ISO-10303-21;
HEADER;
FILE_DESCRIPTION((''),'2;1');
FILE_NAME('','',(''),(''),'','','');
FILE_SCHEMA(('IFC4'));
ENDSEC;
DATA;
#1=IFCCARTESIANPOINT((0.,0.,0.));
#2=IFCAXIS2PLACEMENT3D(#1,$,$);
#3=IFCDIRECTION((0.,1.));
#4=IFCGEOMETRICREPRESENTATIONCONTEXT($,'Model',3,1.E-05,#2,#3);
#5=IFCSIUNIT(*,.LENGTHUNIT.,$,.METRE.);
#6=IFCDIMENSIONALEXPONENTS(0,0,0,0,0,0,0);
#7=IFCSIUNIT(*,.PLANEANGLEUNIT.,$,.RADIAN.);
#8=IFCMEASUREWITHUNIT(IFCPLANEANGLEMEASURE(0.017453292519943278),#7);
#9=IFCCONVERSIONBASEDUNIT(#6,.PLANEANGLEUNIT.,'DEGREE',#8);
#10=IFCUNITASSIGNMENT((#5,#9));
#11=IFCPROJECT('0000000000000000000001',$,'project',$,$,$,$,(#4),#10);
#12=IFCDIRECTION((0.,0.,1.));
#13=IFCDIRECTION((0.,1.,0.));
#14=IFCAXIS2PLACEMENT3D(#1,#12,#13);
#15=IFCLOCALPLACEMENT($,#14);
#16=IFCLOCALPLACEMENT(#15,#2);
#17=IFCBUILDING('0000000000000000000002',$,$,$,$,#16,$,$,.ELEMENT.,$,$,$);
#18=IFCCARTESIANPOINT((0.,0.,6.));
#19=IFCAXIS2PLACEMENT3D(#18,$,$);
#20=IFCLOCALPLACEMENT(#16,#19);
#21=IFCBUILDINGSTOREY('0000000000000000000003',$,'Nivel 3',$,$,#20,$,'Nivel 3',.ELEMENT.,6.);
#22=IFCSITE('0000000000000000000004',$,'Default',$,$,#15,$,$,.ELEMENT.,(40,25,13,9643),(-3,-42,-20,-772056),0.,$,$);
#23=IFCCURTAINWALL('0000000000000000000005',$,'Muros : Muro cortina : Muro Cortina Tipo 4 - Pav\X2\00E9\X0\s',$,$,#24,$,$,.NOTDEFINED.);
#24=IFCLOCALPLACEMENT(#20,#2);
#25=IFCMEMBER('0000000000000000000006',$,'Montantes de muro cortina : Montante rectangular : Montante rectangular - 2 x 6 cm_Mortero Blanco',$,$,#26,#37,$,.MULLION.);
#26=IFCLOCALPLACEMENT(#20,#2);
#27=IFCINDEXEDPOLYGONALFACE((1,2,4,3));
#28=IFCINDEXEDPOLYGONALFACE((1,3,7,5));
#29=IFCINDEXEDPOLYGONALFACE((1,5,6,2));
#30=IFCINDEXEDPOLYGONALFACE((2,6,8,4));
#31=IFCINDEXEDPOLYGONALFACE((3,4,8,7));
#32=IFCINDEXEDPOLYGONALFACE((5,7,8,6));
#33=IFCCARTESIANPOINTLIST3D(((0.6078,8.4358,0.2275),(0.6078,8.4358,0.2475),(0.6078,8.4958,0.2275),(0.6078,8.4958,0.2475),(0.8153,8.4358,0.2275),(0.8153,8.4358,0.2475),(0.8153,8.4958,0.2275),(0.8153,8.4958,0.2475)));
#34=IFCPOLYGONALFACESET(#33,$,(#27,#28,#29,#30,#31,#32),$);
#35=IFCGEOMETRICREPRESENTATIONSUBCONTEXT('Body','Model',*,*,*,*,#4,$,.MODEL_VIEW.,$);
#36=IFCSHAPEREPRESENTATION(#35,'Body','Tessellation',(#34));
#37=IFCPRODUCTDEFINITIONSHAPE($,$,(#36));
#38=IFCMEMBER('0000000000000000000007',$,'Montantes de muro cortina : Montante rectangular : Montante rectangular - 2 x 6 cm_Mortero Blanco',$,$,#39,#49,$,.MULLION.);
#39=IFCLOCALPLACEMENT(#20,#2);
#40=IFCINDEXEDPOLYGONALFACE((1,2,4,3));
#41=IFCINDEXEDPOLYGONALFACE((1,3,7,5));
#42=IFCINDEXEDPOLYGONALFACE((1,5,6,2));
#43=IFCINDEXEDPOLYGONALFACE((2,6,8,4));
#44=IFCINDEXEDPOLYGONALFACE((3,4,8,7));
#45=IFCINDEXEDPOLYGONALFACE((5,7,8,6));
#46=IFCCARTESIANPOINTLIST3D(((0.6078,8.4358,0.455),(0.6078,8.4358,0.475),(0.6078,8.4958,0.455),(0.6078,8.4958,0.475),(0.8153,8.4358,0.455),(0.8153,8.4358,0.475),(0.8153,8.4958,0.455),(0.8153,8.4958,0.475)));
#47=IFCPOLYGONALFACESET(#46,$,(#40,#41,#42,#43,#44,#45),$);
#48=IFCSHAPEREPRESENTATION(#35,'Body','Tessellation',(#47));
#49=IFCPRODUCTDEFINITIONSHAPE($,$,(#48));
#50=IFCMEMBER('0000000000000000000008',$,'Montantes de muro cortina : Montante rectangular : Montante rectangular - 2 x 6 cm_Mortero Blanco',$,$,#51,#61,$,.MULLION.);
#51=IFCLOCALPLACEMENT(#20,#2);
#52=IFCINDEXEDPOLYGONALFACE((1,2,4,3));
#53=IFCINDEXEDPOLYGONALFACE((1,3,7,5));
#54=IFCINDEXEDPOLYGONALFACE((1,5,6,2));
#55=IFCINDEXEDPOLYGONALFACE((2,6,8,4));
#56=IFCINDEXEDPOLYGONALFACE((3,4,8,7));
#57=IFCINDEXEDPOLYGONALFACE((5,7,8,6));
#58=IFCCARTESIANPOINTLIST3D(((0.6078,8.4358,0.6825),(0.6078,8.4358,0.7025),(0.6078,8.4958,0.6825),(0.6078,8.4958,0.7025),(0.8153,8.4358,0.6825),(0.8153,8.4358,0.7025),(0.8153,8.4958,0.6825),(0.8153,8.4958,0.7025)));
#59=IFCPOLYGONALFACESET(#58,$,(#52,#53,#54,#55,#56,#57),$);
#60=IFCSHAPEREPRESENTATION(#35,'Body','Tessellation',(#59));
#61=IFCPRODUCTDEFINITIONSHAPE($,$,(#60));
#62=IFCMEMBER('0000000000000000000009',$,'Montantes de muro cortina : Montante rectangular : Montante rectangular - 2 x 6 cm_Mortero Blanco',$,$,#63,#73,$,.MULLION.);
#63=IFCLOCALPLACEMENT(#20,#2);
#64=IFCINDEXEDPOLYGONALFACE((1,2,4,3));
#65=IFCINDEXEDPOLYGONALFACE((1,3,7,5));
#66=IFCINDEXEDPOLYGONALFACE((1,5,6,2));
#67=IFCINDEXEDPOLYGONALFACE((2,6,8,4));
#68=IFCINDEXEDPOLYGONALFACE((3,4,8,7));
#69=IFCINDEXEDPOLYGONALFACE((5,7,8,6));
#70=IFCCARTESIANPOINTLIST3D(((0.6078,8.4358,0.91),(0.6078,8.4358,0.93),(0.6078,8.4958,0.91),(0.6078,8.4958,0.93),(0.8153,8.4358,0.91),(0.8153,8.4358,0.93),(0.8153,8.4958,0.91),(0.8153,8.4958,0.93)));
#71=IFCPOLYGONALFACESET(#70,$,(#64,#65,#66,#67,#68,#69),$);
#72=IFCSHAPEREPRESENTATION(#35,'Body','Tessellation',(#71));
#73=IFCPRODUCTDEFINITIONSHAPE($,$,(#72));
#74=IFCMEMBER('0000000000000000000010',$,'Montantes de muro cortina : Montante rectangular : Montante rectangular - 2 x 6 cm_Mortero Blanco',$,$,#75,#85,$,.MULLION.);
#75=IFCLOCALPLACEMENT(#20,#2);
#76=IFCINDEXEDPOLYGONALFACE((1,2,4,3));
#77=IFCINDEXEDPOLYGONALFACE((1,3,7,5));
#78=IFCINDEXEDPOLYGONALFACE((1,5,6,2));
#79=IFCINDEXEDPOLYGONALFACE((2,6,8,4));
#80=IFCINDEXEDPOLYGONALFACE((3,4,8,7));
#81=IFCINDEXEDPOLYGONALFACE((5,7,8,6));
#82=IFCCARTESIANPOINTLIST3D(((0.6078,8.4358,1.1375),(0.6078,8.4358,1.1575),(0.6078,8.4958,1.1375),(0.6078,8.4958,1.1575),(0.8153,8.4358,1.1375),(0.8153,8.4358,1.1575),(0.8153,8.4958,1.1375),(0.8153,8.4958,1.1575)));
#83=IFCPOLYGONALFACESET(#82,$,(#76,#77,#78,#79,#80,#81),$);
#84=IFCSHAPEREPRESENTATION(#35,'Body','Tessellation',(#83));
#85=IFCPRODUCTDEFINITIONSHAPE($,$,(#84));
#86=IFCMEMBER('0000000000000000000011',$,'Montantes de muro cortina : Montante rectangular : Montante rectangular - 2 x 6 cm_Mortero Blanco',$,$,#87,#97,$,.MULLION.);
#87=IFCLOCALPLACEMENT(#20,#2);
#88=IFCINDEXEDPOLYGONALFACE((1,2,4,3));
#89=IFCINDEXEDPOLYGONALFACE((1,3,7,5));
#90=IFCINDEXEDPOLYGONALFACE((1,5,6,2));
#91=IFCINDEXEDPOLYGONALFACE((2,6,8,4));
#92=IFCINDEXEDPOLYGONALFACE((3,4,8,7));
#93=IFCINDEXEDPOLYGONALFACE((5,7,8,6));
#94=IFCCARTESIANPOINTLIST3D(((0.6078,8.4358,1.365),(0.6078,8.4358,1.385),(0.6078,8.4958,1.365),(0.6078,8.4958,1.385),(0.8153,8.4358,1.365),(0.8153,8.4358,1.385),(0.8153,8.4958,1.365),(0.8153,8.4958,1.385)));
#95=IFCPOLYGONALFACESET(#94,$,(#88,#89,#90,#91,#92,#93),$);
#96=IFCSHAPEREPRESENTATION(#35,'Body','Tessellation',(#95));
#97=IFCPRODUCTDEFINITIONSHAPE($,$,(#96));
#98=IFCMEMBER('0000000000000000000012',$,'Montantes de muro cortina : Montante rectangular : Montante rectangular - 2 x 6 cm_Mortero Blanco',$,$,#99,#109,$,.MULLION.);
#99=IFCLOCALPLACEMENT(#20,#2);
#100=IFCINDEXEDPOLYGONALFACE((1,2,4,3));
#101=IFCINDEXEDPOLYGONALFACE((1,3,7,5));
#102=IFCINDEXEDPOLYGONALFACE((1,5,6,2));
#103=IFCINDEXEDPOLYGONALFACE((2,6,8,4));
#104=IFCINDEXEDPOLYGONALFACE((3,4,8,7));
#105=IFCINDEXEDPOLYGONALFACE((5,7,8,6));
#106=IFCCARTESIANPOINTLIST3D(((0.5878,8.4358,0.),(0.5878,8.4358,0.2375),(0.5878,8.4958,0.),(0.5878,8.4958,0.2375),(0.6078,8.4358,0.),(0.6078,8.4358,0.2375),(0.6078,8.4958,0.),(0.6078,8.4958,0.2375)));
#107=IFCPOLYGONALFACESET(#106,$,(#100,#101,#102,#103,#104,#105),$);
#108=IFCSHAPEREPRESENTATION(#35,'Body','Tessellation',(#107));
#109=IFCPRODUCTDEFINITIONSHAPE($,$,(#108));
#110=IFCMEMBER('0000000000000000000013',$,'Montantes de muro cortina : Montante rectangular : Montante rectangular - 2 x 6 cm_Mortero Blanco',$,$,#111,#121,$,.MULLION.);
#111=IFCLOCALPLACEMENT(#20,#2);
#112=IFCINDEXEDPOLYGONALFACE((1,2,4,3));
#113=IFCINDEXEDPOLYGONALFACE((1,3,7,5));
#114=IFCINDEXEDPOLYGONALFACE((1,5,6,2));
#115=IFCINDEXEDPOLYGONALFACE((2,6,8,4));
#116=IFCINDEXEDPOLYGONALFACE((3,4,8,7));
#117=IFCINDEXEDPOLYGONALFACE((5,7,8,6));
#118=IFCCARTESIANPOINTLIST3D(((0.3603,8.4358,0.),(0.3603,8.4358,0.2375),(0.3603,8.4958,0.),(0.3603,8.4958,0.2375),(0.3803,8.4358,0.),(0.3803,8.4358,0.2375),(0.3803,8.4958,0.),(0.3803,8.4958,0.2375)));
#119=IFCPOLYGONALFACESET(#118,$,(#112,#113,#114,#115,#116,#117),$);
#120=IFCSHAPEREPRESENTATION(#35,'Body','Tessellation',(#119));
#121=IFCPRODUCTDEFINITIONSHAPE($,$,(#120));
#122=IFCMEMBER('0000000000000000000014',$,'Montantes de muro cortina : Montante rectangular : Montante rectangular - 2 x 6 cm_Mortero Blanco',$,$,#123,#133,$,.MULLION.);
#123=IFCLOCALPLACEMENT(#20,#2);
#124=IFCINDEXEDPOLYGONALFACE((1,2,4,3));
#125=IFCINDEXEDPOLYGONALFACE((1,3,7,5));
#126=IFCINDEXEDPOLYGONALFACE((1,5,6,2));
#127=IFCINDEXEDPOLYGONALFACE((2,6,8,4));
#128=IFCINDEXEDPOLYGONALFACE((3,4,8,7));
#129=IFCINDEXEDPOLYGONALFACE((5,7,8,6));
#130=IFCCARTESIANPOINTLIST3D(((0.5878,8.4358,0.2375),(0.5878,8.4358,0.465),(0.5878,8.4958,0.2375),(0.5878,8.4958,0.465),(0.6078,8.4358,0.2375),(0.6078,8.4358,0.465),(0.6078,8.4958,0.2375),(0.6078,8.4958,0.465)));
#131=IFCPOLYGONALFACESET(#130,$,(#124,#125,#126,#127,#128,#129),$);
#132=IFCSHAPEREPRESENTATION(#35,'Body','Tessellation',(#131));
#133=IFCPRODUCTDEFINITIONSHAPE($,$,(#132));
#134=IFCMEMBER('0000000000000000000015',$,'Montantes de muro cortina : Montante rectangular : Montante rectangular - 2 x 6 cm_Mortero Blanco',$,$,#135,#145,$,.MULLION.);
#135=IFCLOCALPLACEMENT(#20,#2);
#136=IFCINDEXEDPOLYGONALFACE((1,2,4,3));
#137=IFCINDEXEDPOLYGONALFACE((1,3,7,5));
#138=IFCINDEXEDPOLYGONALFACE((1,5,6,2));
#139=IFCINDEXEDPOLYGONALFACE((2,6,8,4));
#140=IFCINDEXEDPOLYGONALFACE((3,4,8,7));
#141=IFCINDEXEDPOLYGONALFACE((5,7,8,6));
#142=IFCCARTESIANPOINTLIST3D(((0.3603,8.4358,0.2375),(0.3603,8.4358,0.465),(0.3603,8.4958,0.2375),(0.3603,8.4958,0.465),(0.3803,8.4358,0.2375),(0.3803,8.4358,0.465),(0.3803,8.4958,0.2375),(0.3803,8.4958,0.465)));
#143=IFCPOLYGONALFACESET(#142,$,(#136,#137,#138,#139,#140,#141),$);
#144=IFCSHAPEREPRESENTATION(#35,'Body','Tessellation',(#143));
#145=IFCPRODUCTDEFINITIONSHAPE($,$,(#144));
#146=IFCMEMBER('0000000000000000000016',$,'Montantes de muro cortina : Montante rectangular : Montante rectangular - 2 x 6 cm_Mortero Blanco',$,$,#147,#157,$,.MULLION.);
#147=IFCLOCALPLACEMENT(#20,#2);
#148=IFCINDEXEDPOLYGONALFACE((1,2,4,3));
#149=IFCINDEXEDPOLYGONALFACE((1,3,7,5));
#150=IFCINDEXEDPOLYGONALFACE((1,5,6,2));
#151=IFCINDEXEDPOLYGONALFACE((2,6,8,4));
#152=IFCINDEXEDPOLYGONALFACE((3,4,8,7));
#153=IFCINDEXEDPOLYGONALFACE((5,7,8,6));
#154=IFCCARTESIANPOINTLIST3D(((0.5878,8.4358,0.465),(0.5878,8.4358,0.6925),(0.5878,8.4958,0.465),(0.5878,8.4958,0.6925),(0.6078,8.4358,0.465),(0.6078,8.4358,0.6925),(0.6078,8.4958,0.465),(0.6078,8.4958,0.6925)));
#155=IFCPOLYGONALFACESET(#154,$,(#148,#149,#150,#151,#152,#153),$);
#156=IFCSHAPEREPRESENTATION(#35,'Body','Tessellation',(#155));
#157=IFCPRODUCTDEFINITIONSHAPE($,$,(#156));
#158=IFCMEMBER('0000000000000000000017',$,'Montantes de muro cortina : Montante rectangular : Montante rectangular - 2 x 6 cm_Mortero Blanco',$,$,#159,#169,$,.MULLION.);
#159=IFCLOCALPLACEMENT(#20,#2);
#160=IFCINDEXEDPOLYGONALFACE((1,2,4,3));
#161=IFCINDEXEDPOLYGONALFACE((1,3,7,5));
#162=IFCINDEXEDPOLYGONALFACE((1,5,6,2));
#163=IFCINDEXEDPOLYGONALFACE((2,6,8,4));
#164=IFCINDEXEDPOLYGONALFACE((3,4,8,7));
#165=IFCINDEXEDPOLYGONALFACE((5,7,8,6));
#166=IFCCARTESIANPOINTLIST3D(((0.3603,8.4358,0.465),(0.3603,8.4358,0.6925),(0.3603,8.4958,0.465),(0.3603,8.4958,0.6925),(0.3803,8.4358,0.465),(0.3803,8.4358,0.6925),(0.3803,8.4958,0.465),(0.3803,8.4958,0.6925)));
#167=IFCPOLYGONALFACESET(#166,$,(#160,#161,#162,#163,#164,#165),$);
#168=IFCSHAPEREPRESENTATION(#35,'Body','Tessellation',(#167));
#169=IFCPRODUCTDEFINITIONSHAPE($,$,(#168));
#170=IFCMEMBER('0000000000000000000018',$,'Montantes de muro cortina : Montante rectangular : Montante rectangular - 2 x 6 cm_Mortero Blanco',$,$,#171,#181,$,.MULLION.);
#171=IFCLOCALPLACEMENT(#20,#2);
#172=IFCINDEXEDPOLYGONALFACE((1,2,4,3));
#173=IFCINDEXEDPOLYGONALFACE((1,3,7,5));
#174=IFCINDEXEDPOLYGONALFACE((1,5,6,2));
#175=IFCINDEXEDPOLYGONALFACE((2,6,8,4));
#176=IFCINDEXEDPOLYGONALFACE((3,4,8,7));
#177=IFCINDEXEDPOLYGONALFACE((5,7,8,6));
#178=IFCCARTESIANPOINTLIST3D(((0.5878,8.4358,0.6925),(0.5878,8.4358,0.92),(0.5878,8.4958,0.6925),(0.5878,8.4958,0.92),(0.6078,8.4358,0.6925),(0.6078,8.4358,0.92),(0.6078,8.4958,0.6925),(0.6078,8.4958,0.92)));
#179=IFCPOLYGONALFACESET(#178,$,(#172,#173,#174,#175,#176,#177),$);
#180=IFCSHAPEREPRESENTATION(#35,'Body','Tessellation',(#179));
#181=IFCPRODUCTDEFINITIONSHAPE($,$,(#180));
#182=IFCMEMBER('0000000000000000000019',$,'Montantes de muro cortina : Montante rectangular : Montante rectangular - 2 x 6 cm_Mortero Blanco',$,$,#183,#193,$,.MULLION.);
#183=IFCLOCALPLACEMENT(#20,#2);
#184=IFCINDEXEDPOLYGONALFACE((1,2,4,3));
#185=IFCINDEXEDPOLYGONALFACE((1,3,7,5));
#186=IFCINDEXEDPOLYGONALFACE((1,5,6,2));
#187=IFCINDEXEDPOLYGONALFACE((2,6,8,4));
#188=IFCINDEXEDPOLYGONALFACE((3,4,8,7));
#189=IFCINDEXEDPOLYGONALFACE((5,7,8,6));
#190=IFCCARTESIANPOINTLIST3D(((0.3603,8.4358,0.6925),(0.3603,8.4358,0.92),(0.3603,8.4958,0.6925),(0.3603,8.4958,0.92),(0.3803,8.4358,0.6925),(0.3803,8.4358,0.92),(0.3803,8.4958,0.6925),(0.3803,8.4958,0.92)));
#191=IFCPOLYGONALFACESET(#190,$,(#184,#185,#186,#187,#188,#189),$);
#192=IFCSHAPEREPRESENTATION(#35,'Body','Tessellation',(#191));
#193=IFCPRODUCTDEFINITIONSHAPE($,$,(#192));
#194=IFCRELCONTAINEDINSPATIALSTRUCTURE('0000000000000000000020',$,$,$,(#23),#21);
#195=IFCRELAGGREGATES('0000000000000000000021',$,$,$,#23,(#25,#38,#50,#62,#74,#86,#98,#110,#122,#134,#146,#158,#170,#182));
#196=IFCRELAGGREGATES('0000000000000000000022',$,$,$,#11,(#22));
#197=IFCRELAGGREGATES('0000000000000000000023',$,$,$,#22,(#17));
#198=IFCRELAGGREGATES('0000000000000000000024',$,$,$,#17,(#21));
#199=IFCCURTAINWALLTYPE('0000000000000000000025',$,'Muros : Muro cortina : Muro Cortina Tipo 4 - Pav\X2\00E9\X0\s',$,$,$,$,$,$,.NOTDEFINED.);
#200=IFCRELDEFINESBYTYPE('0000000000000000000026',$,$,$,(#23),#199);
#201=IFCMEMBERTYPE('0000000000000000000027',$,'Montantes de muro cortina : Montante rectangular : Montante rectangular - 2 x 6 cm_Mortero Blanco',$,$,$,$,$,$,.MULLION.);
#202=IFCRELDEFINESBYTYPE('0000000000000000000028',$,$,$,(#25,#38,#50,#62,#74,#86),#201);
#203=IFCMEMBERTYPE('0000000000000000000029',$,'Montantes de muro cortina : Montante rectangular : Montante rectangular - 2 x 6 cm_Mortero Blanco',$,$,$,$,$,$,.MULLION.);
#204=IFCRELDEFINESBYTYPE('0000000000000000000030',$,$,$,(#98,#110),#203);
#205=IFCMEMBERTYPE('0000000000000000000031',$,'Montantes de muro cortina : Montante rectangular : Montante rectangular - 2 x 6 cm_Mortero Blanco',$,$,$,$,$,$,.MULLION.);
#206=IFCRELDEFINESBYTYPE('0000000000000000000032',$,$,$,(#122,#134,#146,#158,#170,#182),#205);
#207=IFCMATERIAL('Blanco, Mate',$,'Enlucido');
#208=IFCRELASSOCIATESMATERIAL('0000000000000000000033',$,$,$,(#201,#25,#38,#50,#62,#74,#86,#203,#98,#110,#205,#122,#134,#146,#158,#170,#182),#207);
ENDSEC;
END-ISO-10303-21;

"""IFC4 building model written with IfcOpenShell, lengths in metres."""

from ifc_helpers import new_model, entity, si_unit, converted_unit, direction, frame, origin, place, context, subcontext, project, spatial, indexed_curve, outline, extrude, source, transform, mapped, material, type_object, type_shapes, element, aggregate, save


model = new_model("IFC4")

# Units and contexts
model_context = context("Model", 3, precision=1e-05, world=origin(), true_north=direction((0.0, 1.0)))
body_context = subcontext(model_context, "Body", "Model", "MODEL_VIEW")
ifc_project = project(units=[si_unit("LENGTHUNIT", "METRE"), converted_unit("PLANEANGLEUNIT", "DEGREE", entity("IfcPlaneAngleMeasure", 0.017453292519943278), si_unit("PLANEANGLEUNIT", "RADIAN"), dimensions=[0, 0, 0, 0, 0, 0, 0])], contexts=[model_context])

# Site, building, storey
site_placement = place(None, frame((0.0, 0.0, 0.0), z_axis=(0.0, 0.0, 1.0), x_axis=(0.0, 1.0, 0.0)))
site = spatial("IfcSite", under=ifc_project, at=site_placement, Name="Default", CompositionType="ELEMENT", RefLatitude=(40, 25, 13, 9643), RefLongitude=(-3, -42, -20, -772056), RefElevation=0.0)
building_placement = place(site_placement, origin())
building = spatial("IfcBuilding", under=site, at=building_placement, CompositionType="ELEMENT")
storey_placement = place(building_placement, frame((0.0, 0.0, 6.0)))
storey = spatial("IfcBuildingStorey", under=building, at=storey_placement, Name="Nivel 3", LongName="Nivel 3", CompositionType="ELEMENT", Elevation=6.0)

# Curtain wall, members
curtain_wall_type = type_object("IfcCurtainWallType", Name="Muros : Muro cortina : Muro Cortina Tipo 4 - Pavés", PredefinedType="NOTDEFINED")
curtain_wall_placement = place(storey_placement, frame((0.0, 0.0, -6.0)))
curtain_wall = element("IfcCurtainWall", 1, at=curtain_wall_placement, inside=storey, type_object=curtain_wall_type, Name="Muros : Muro cortina : Muro Cortina Tipo 4 - Pavés", PredefinedType="NOTDEFINED")
ifc_material_1 = material(Name="Blanco, Mate", Category="Enlucido")
member_type_1 = type_object("IfcMemberType", Name="Montantes de muro cortina : Montante rectangular : Montante rectangular - 2 x 6 cm_Mortero Blanco", PredefinedType="MULLION", material=ifc_material_1)
shared_shape_1 = source(origin(), body_context, "Body", "SweptSolid", [
    extrude(outline(indexed_curve([(-0.01, -0.03), (0.01, -0.03), (0.01, 0.03), (-0.01, 0.03), (-0.01, -0.03)], self_intersect=False)), frame((0.0, 0.0, -0.2075), z_axis=(0.0, 0.0, 1.0), x_axis=(-1.0, 0.0, 0.0)), (0.0, 0.0, 1.0), 0.2075),
])
type_shapes(member_type_1, [shared_shape_1])
member_1_placement = place(curtain_wall_placement, frame((0.6078, 8.4658, 6.2375), z_axis=(-1.0, 0.0, 0.0), x_axis=(0.0, 0.0, 1.0)))
member_1 = element("IfcMember", 2, at=member_1_placement, type_object=member_type_1, material=ifc_material_1, Name="Montantes de muro cortina : Montante rectangular : Montante rectangular - 2 x 6 cm_Mortero Blanco", PredefinedType="MULLION", context=body_context, shape_type="MappedRepresentation", body=[
    mapped(shared_shape_1, transform((0.0, 0.0, 0.0), scale=1.0)),
])
member_2_placement = place(curtain_wall_placement, frame((0.6078, 8.4658, 6.465), z_axis=(-1.0, 0.0, 0.0), x_axis=(0.0, 0.0, 1.0)))
member_2 = element("IfcMember", 3, at=member_2_placement, type_object=member_type_1, material=ifc_material_1, Name="Montantes de muro cortina : Montante rectangular : Montante rectangular - 2 x 6 cm_Mortero Blanco", PredefinedType="MULLION", context=body_context, shape_type="MappedRepresentation", body=[
    mapped(shared_shape_1, transform((0.0, 0.0, 0.0), scale=1.0)),
])
member_3_placement = place(curtain_wall_placement, frame((0.6078, 8.4658, 6.6925), z_axis=(-1.0, 0.0, 0.0), x_axis=(0.0, 0.0, 1.0)))
member_3 = element("IfcMember", 4, at=member_3_placement, type_object=member_type_1, material=ifc_material_1, Name="Montantes de muro cortina : Montante rectangular : Montante rectangular - 2 x 6 cm_Mortero Blanco", PredefinedType="MULLION", context=body_context, shape_type="MappedRepresentation", body=[
    mapped(shared_shape_1, transform((0.0, 0.0, 0.0), scale=1.0)),
])
member_4_placement = place(curtain_wall_placement, frame((0.6078, 8.4658, 6.92), z_axis=(-1.0, 0.0, 0.0), x_axis=(0.0, 0.0, 1.0)))
member_4 = element("IfcMember", 5, at=member_4_placement, type_object=member_type_1, material=ifc_material_1, Name="Montantes de muro cortina : Montante rectangular : Montante rectangular - 2 x 6 cm_Mortero Blanco", PredefinedType="MULLION", context=body_context, shape_type="MappedRepresentation", body=[
    mapped(shared_shape_1, transform((0.0, 0.0, 0.0), scale=1.0)),
])
member_5_placement = place(curtain_wall_placement, frame((0.6078, 8.4658, 7.1475), z_axis=(-1.0, 0.0, 0.0), x_axis=(0.0, 0.0, 1.0)))
member_5 = element("IfcMember", 6, at=member_5_placement, type_object=member_type_1, material=ifc_material_1, Name="Montantes de muro cortina : Montante rectangular : Montante rectangular - 2 x 6 cm_Mortero Blanco", PredefinedType="MULLION", context=body_context, shape_type="MappedRepresentation", body=[
    mapped(shared_shape_1, transform((0.0, 0.0, 0.0), scale=1.0)),
])
member_6_placement = place(curtain_wall_placement, frame((0.6078, 8.4658, 7.375), z_axis=(-1.0, 0.0, 0.0), x_axis=(0.0, 0.0, 1.0)))
member_6 = element("IfcMember", 7, at=member_6_placement, type_object=member_type_1, material=ifc_material_1, Name="Montantes de muro cortina : Montante rectangular : Montante rectangular - 2 x 6 cm_Mortero Blanco", PredefinedType="MULLION", context=body_context, shape_type="MappedRepresentation", body=[
    mapped(shared_shape_1, transform((0.0, 0.0, 0.0), scale=1.0)),
])
member_type_2 = type_object("IfcMemberType", Name="Montantes de muro cortina : Montante rectangular : Montante rectangular - 2 x 6 cm_Mortero Blanco", PredefinedType="MULLION", material=ifc_material_1)
shared_shape_2 = source(origin(), body_context, "Body", "SweptSolid", [
    extrude(outline(indexed_curve([(-0.01, -0.03), (0.01, -0.03), (0.01, 0.03), (-0.01, 0.03), (-0.01, -0.03)], self_intersect=False)), frame((0.0, 0.0, -0.2375), z_axis=(0.0, 0.0, 1.0), x_axis=(-1.0, 0.0, 0.0)), (0.0, 0.0, 1.0), 0.2375),
])
type_shapes(member_type_2, [shared_shape_2])
member_7_placement = place(curtain_wall_placement, frame((0.5978, 8.4658, 6.0), z_axis=(0.0, 0.0, -1.0), x_axis=(-1.0, 0.0, 0.0)))
member_7 = element("IfcMember", 8, at=member_7_placement, type_object=member_type_2, material=ifc_material_1, Name="Montantes de muro cortina : Montante rectangular : Montante rectangular - 2 x 6 cm_Mortero Blanco", PredefinedType="MULLION", context=body_context, shape_type="MappedRepresentation", body=[
    mapped(shared_shape_2, transform((0.0, 0.0, 0.0), scale=1.0)),
])
member_8_placement = place(curtain_wall_placement, frame((0.3703, 8.4658, 6.0), z_axis=(0.0, 0.0, -1.0), x_axis=(-1.0, 0.0, 0.0)))
member_8 = element("IfcMember", 9, at=member_8_placement, type_object=member_type_2, material=ifc_material_1, Name="Montantes de muro cortina : Montante rectangular : Montante rectangular - 2 x 6 cm_Mortero Blanco", PredefinedType="MULLION", context=body_context, shape_type="MappedRepresentation", body=[
    mapped(shared_shape_2, transform((0.0, 0.0, 0.0), scale=1.0)),
])
member_type_3 = type_object("IfcMemberType", Name="Montantes de muro cortina : Montante rectangular : Montante rectangular - 2 x 6 cm_Mortero Blanco", PredefinedType="MULLION", material=ifc_material_1)
shared_shape_3 = source(origin(), body_context, "Body", "SweptSolid", [
    extrude(outline(indexed_curve([(-0.01, -0.03), (0.01, -0.03), (0.01, 0.03), (-0.01, 0.03), (-0.01, -0.03)], self_intersect=False)), frame((0.0, 0.0, -0.2275), z_axis=(0.0, 0.0, 1.0), x_axis=(-1.0, 0.0, 0.0)), (0.0, 0.0, 1.0), 0.2275),
])
type_shapes(member_type_3, [shared_shape_3])
member_9_placement = place(curtain_wall_placement, frame((0.5978, 8.4658, 6.2375), z_axis=(0.0, 0.0, -1.0), x_axis=(-1.0, 0.0, 0.0)))
member_9 = element("IfcMember", 10, at=member_9_placement, type_object=member_type_3, material=ifc_material_1, Name="Montantes de muro cortina : Montante rectangular : Montante rectangular - 2 x 6 cm_Mortero Blanco", PredefinedType="MULLION", context=body_context, shape_type="MappedRepresentation", body=[
    mapped(shared_shape_3, transform((0.0, 0.0, 0.0), scale=1.0)),
])
member_10_placement = place(curtain_wall_placement, frame((0.3703, 8.4658, 6.2375), z_axis=(0.0, 0.0, -1.0), x_axis=(-1.0, 0.0, 0.0)))
member_10 = element("IfcMember", 11, at=member_10_placement, type_object=member_type_3, material=ifc_material_1, Name="Montantes de muro cortina : Montante rectangular : Montante rectangular - 2 x 6 cm_Mortero Blanco", PredefinedType="MULLION", context=body_context, shape_type="MappedRepresentation", body=[
    mapped(shared_shape_3, transform((0.0, 0.0, 0.0), scale=1.0)),
])
member_11_placement = place(curtain_wall_placement, frame((0.5978, 8.4658, 6.465), z_axis=(0.0, 0.0, -1.0), x_axis=(-1.0, 0.0, 0.0)))
member_11 = element("IfcMember", 12, at=member_11_placement, type_object=member_type_3, material=ifc_material_1, Name="Montantes de muro cortina : Montante rectangular : Montante rectangular - 2 x 6 cm_Mortero Blanco", PredefinedType="MULLION", context=body_context, shape_type="MappedRepresentation", body=[
    mapped(shared_shape_3, transform((0.0, 0.0, 0.0), scale=1.0)),
])
member_12_placement = place(curtain_wall_placement, frame((0.3703, 8.4658, 6.465), z_axis=(0.0, 0.0, -1.0), x_axis=(-1.0, 0.0, 0.0)))
member_12 = element("IfcMember", 13, at=member_12_placement, type_object=member_type_3, material=ifc_material_1, Name="Montantes de muro cortina : Montante rectangular : Montante rectangular - 2 x 6 cm_Mortero Blanco", PredefinedType="MULLION", context=body_context, shape_type="MappedRepresentation", body=[
    mapped(shared_shape_3, transform((0.0, 0.0, 0.0), scale=1.0)),
])
member_13_placement = place(curtain_wall_placement, frame((0.5978, 8.4658, 6.6925), z_axis=(0.0, 0.0, -1.0), x_axis=(-1.0, 0.0, 0.0)))
member_13 = element("IfcMember", 14, at=member_13_placement, type_object=member_type_3, material=ifc_material_1, Name="Montantes de muro cortina : Montante rectangular : Montante rectangular - 2 x 6 cm_Mortero Blanco", PredefinedType="MULLION", context=body_context, shape_type="MappedRepresentation", body=[
    mapped(shared_shape_3, transform((0.0, 0.0, 0.0), scale=1.0)),
])
member_14_placement = place(curtain_wall_placement, frame((0.3703, 8.4658, 6.6925), z_axis=(0.0, 0.0, -1.0), x_axis=(-1.0, 0.0, 0.0)))
member_14 = element("IfcMember", 15, at=member_14_placement, type_object=member_type_3, material=ifc_material_1, Name="Montantes de muro cortina : Montante rectangular : Montante rectangular - 2 x 6 cm_Mortero Blanco", PredefinedType="MULLION", context=body_context, shape_type="MappedRepresentation", body=[
    mapped(shared_shape_3, transform((0.0, 0.0, 0.0), scale=1.0)),
])
aggregate(curtain_wall, [member_1, member_2, member_3, member_4, member_5, member_6, member_7, member_8, member_9, member_10, member_11, member_12, member_13, member_14])

save(model, "model.ifc")
